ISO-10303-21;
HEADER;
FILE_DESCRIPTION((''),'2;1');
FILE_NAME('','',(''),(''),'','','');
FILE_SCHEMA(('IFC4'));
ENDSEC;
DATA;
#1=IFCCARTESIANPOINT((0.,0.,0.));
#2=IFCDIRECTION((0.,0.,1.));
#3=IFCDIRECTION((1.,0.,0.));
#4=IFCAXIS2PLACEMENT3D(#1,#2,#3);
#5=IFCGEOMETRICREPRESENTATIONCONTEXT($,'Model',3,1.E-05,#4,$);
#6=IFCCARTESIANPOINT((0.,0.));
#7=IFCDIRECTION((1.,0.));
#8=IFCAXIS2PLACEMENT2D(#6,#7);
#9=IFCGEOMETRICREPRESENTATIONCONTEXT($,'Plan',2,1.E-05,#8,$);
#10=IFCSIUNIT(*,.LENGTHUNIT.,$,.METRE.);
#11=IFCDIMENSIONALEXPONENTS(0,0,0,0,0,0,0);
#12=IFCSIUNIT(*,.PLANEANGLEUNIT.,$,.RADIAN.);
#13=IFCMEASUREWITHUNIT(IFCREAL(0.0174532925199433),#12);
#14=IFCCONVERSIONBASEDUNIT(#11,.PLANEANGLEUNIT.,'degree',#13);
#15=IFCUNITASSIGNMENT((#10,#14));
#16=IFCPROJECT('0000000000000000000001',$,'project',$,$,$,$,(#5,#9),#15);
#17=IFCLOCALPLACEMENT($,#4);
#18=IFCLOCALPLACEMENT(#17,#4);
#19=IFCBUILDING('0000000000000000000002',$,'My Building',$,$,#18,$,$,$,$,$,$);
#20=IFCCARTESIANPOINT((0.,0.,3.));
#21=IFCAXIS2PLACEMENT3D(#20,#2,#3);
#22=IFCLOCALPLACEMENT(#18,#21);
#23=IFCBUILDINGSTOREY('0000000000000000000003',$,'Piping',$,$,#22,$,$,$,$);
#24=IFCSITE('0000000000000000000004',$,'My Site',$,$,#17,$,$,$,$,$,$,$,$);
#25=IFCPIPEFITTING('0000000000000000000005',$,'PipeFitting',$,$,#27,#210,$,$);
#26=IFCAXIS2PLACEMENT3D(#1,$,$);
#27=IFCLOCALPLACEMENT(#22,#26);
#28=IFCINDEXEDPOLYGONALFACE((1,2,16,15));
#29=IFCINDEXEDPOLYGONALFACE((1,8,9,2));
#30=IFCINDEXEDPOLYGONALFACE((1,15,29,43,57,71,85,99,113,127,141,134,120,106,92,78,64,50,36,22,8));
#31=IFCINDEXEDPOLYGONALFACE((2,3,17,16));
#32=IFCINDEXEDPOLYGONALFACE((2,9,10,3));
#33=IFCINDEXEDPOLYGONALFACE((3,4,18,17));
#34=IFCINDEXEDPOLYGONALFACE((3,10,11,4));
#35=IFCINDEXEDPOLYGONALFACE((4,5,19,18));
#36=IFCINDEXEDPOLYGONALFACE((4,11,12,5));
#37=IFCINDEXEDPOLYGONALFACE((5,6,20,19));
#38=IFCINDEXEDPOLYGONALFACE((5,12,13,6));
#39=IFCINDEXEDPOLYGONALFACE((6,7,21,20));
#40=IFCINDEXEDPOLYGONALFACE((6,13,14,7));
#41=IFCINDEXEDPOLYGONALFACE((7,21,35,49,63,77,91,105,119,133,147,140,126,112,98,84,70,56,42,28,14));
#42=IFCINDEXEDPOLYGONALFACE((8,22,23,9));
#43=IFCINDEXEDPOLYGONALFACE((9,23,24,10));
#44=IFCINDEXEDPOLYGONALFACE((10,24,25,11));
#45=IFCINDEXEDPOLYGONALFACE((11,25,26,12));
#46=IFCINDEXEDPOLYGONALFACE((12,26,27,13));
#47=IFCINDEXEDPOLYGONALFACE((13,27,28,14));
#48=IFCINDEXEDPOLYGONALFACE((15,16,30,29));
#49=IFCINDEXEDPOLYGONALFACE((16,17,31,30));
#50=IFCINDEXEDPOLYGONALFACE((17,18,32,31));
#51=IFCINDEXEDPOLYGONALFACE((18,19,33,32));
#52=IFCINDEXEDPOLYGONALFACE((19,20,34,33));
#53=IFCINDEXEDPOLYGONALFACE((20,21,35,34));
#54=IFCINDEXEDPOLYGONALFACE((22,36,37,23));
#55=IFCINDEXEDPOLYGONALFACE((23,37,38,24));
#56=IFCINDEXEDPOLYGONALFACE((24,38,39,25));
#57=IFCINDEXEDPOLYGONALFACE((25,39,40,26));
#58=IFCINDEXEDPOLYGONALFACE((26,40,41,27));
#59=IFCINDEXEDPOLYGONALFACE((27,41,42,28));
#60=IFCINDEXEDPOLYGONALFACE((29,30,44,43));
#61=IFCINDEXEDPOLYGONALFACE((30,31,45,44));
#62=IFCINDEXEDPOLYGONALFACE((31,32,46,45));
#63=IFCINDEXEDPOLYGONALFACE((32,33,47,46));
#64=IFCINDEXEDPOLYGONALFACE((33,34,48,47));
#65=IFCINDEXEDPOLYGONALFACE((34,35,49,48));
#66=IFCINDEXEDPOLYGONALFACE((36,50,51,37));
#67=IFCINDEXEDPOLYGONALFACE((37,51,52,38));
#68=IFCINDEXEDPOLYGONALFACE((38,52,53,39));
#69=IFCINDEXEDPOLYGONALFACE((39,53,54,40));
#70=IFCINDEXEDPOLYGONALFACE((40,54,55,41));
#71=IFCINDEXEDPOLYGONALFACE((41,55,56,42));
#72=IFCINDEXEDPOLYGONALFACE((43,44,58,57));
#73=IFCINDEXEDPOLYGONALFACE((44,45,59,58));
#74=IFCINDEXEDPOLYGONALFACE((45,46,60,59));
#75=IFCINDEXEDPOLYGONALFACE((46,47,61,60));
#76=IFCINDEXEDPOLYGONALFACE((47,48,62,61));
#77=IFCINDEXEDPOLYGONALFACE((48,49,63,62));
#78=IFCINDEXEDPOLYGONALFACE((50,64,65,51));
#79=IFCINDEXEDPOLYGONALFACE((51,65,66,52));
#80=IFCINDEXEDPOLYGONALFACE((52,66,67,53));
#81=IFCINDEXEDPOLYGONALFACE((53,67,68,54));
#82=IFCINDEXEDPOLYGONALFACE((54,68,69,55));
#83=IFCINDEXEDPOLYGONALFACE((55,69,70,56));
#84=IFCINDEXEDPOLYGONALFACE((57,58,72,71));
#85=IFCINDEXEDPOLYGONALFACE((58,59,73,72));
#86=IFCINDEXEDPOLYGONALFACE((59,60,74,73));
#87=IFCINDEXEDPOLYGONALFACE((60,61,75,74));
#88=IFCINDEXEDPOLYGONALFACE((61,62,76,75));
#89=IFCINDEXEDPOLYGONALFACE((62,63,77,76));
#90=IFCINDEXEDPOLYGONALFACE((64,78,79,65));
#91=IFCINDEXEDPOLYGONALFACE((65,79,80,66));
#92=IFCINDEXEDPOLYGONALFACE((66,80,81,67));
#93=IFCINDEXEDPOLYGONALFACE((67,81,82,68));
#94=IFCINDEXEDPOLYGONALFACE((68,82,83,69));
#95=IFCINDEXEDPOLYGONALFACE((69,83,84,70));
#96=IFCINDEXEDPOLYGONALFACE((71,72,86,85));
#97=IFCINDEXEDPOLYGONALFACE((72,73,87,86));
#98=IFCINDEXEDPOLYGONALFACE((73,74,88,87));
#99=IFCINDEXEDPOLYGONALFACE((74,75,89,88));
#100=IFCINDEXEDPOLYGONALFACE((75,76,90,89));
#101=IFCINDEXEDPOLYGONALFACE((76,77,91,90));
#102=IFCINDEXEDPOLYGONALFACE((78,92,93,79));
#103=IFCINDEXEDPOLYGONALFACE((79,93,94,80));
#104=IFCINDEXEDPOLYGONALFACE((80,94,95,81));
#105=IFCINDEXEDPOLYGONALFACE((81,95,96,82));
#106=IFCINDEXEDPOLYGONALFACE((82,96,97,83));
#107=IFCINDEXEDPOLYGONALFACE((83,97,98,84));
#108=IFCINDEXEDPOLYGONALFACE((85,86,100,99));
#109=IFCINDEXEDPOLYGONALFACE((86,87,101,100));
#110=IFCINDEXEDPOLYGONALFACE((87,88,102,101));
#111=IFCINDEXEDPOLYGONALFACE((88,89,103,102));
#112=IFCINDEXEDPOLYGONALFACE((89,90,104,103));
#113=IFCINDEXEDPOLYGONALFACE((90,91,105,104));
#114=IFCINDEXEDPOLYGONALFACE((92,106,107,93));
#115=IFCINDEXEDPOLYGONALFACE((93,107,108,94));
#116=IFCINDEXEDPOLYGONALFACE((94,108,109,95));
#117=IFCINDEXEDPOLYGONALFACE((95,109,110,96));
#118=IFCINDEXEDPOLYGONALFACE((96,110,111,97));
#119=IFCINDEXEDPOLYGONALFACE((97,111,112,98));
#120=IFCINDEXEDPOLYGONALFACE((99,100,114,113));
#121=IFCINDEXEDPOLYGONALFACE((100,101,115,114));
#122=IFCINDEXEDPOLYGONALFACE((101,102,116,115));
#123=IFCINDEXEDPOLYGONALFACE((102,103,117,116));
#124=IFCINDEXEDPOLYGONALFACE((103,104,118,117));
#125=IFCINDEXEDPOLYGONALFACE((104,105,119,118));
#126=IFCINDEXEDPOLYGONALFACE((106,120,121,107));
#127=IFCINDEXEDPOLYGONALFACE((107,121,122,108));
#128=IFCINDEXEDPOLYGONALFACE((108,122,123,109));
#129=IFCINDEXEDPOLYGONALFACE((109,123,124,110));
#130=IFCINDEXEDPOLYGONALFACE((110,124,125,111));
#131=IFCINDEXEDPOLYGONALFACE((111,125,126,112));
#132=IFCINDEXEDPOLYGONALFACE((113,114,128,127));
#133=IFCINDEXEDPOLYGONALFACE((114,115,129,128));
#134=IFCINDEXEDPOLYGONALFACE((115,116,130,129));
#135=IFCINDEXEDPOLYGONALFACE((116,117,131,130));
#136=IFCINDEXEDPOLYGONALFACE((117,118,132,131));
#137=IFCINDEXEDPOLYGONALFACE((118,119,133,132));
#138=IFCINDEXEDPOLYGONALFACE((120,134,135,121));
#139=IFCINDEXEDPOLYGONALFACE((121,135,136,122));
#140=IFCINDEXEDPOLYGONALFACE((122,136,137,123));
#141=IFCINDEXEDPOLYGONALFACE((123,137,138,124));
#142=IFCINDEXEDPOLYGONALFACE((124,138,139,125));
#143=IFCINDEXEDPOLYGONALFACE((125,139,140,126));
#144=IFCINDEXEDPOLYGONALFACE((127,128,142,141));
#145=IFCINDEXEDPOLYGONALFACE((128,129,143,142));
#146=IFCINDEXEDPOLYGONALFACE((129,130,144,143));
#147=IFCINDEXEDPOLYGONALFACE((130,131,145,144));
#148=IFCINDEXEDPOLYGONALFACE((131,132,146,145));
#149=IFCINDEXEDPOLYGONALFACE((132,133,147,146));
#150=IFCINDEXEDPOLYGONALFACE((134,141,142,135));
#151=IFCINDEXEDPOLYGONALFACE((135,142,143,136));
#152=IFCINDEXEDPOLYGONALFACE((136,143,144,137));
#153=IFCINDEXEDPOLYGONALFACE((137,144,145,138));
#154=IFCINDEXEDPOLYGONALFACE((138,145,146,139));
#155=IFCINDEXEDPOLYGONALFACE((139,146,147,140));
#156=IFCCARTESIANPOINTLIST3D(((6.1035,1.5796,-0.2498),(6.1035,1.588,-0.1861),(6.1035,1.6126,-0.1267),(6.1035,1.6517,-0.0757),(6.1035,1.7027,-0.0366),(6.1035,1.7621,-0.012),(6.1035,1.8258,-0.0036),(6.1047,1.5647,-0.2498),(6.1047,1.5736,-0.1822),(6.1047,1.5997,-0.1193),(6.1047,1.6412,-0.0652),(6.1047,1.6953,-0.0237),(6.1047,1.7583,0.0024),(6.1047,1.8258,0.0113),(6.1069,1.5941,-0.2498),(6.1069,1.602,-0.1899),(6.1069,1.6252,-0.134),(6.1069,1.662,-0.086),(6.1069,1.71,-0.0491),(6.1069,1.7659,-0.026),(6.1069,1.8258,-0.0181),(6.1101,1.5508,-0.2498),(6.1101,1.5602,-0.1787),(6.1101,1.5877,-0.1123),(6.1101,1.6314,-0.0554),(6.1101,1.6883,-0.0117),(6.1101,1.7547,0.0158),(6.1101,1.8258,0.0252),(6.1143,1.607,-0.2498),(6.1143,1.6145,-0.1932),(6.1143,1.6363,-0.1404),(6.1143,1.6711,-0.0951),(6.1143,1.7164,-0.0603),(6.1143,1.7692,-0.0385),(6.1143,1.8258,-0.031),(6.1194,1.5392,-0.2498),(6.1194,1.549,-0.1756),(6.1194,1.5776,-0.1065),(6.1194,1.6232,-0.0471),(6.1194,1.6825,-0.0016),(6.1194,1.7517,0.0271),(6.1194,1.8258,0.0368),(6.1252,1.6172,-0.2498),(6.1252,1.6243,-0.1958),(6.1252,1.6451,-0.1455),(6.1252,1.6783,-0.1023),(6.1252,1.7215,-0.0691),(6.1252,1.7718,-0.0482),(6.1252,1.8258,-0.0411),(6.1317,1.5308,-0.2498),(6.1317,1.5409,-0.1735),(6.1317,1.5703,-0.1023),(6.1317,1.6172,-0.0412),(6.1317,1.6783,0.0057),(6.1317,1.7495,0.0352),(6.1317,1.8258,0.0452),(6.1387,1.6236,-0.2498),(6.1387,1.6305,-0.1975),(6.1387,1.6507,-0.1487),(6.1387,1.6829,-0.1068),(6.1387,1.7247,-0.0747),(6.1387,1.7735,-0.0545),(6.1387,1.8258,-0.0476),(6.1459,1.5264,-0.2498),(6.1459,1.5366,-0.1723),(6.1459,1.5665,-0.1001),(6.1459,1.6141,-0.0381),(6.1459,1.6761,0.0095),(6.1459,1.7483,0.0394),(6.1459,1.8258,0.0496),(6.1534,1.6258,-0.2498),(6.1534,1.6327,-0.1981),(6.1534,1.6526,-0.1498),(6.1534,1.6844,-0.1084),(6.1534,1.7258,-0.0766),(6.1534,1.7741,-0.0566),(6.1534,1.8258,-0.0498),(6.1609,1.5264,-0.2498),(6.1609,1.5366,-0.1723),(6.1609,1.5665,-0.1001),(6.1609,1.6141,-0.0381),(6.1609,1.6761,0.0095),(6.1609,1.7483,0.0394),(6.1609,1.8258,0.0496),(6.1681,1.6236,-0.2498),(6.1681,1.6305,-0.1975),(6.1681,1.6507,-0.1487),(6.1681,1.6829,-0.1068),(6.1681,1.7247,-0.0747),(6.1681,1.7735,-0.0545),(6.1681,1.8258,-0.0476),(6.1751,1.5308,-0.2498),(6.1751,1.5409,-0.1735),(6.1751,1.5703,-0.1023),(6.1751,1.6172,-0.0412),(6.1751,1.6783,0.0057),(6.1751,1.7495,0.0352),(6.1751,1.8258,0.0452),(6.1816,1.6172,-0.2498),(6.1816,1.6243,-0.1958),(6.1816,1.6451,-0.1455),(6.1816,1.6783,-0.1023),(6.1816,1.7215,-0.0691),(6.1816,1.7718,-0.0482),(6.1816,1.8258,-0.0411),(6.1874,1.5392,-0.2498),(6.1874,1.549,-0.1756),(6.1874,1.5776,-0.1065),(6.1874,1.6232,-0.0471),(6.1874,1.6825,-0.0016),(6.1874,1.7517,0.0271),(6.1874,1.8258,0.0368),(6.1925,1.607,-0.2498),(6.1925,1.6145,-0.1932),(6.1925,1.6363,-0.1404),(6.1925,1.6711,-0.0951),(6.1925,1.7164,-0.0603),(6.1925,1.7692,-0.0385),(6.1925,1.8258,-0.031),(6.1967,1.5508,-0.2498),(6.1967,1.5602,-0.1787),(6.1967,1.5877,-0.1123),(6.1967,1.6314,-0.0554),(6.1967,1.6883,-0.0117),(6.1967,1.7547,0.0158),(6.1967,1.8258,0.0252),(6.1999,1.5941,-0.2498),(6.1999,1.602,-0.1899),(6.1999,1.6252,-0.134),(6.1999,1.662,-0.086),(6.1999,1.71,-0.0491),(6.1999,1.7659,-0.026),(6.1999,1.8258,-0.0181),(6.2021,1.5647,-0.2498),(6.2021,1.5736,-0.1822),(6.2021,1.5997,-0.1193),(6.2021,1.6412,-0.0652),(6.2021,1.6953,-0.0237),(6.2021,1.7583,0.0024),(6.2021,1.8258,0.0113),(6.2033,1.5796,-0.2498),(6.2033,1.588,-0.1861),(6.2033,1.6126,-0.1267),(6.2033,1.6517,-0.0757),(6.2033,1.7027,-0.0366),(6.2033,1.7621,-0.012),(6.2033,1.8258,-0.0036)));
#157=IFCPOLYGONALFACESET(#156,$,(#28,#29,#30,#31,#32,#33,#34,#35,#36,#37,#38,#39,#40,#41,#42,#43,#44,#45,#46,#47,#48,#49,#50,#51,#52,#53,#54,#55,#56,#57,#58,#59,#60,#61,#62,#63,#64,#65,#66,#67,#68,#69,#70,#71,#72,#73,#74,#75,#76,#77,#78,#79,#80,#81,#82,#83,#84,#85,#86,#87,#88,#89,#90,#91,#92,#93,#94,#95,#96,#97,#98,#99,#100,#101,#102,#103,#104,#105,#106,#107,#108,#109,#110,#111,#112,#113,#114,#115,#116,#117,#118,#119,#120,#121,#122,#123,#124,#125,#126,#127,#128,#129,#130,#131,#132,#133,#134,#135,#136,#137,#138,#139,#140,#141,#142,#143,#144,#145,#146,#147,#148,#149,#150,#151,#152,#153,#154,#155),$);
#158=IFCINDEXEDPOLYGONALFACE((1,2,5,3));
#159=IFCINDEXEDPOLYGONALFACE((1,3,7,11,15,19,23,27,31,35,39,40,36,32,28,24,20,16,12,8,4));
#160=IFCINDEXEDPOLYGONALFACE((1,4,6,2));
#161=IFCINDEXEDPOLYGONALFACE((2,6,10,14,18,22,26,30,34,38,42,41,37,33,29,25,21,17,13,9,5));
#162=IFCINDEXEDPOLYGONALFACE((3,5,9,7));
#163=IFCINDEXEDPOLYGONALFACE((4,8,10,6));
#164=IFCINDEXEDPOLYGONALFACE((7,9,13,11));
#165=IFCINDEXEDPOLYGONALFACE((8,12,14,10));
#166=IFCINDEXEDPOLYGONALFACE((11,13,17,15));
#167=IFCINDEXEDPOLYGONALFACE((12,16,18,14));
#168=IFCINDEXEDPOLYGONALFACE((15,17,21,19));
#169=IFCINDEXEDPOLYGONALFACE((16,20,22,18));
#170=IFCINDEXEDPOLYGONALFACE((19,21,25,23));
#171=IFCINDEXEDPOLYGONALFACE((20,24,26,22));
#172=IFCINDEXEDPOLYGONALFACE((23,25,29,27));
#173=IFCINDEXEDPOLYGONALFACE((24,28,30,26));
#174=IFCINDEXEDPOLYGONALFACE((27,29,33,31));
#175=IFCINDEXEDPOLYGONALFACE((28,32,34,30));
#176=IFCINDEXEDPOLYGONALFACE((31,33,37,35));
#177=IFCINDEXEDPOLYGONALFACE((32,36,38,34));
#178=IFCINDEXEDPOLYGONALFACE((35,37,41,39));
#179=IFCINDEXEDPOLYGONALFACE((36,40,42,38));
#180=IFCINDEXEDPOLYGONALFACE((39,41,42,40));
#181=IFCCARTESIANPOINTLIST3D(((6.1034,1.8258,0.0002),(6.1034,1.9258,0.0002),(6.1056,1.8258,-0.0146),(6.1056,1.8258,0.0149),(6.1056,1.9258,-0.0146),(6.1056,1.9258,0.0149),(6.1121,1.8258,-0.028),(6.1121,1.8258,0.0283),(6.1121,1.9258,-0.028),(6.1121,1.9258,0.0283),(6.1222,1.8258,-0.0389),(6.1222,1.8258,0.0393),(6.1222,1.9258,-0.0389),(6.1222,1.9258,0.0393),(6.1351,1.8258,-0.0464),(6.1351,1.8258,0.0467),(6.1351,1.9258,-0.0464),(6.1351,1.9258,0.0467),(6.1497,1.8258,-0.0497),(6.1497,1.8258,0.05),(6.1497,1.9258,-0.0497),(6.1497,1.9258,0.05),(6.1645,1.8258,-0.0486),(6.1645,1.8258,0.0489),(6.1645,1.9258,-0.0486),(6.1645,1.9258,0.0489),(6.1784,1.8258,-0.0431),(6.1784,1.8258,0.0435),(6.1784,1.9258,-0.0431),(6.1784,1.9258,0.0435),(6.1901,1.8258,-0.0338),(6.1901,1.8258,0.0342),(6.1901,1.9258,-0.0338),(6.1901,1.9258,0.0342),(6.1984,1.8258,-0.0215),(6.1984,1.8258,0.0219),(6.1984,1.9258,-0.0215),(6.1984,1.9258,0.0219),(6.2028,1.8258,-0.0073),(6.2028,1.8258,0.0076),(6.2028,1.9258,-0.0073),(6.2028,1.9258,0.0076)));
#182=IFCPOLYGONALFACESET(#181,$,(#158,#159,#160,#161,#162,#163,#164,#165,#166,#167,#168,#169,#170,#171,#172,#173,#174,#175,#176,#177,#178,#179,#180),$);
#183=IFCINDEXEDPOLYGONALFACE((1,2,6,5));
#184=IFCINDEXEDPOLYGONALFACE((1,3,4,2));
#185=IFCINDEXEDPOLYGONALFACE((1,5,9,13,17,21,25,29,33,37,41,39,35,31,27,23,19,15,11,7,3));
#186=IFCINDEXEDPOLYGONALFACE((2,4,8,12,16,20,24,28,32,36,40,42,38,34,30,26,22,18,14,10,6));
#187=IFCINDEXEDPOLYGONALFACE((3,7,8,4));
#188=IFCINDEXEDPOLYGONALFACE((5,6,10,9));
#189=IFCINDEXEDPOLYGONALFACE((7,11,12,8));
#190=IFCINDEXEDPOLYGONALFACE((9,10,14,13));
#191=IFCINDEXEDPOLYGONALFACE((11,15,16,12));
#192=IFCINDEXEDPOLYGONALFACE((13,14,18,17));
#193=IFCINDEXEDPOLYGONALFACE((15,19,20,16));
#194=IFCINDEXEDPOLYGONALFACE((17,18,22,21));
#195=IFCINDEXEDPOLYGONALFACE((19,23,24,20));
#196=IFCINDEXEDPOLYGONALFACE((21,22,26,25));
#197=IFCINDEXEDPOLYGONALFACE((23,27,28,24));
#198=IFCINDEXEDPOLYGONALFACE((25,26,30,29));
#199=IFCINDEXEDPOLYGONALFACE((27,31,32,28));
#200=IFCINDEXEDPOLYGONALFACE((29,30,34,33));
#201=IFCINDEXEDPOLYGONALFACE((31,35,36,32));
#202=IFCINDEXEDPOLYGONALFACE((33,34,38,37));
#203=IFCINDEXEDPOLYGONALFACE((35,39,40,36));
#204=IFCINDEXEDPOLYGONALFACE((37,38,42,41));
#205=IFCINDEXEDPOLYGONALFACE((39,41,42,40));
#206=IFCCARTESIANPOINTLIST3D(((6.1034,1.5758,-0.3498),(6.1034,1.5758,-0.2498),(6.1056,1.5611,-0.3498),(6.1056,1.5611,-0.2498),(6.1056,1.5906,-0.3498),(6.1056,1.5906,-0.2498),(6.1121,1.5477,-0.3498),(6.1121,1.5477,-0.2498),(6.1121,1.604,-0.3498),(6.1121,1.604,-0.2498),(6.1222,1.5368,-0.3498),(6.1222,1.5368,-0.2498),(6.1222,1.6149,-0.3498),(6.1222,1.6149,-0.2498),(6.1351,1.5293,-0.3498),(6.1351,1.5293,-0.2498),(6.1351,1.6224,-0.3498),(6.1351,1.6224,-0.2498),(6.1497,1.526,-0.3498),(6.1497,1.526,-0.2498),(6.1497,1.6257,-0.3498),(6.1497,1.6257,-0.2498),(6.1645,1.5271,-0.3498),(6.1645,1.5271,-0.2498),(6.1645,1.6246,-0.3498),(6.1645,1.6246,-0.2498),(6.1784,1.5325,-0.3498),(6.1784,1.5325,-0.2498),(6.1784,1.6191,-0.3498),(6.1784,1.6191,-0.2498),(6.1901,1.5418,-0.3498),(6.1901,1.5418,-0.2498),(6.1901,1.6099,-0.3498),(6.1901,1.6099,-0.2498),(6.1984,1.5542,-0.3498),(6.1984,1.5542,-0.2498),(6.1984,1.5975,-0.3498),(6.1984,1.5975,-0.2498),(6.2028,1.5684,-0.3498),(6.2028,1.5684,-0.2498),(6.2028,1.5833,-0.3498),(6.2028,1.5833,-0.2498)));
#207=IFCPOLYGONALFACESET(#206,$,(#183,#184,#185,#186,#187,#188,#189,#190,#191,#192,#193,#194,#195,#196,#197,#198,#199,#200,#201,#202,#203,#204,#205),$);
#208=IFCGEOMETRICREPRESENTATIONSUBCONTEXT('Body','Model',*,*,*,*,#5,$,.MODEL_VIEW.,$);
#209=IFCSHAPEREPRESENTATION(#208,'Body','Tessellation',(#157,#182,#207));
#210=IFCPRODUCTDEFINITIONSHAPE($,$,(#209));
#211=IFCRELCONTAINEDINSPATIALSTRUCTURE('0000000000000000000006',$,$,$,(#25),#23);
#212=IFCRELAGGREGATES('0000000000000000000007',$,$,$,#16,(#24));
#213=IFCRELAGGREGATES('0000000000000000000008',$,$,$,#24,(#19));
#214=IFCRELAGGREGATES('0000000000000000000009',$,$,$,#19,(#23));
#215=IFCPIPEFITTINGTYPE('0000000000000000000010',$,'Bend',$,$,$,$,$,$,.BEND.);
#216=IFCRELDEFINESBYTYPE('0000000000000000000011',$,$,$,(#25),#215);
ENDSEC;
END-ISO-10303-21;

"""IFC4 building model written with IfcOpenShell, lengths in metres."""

from ifc_helpers import new_model, entity, si_unit, converted_unit, frame, origin_with_axes, origin_2d_with_axis, place, context, subcontext, project, spatial, circle, extrude, source, transform, mapped, type_object, type_shapes, element, save


model = new_model("IFC4")

# Units and contexts
model_context = context("Model", 3, precision=1e-05, world=origin_with_axes())
plan_context = context("Plan", 2, precision=1e-05, world=origin_2d_with_axis())
body_context = subcontext(model_context, "Body", "Model", "MODEL_VIEW")
ifc_project = project(units=[si_unit("LENGTHUNIT", "METRE"), converted_unit("PLANEANGLEUNIT", "degree", entity("IfcReal", 0.0174532925199433), si_unit("PLANEANGLEUNIT", "RADIAN"), dimensions=[0, 0, 0, 0, 0, 0, 0])], contexts=[model_context, plan_context])

# Site, building, storey
site_placement = place(None, origin_with_axes())
site = spatial("IfcSite", under=ifc_project, at=site_placement, Name="My Site")
building_placement = place(site_placement, origin_with_axes())
building = spatial("IfcBuilding", under=site, at=building_placement, Name="My Building")
storey_placement = place(building_placement, frame((0.0, 0.0, 3.0), z_axis=(0.0, 0.0, 1.0), x_axis=(1.0, 0.0, 0.0)))
storey = spatial("IfcBuildingStorey", under=building, at=storey_placement, Name="Piping")

# Pipe fitting
pipe_fitting_type = type_object("IfcPipeFittingType", Name="Bend", PredefinedType="BEND")
shared_shape = source(origin_with_axes(), body_context, "Body", "SolidModel", [
    entity("IfcSweptDiskSolid", entity("IfcIndexedPolyCurve", entity("IfcCartesianPointList3D", [[0.0, 0.0, -0.1], [0.0, -0.0732, -0.2768], [0.0, -0.25, -0.35]]), [entity("IfcArcIndex", [1, 2, 3])]), 0.05),
    extrude(circle(Radius=0.05), origin_with_axes(), (0.0, 0.0, -1.0), 0.1),
    extrude(circle(Radius=0.05), frame((0.0, -0.25, -0.35), z_axis=(0.0, -1.0, 0.0), x_axis=(1.0, 0.0, 0.0)), (0.0, 0.0, 1.0), 0.1),
])
type_shapes(pipe_fitting_type, [shared_shape])
for number, where, z_axis, x_axis, name in (
    (1, (6.1534, 1.9258, 0.0002), (0.0, 1.0, 0.0), (-1.0, 0.0, 0.0), "PipeFitting"),
):
    element("IfcPipeFitting", number, at=place(storey_placement, frame(where, z_axis=z_axis, x_axis=x_axis)), inside=storey, type_object=pipe_fitting_type, Name=name, context=body_context, shape_type="MappedRepresentation", body=[
        mapped(shared_shape, transform((0.0, 0.0, 0.0), x_axis=(1.0, 0.0, 0.0), y_axis=(0.0, 1.0, 0.0), z_axis=(0.0, 0.0, 1.0), scale=1.0)),
    ])

save(model, "model.ifc")
